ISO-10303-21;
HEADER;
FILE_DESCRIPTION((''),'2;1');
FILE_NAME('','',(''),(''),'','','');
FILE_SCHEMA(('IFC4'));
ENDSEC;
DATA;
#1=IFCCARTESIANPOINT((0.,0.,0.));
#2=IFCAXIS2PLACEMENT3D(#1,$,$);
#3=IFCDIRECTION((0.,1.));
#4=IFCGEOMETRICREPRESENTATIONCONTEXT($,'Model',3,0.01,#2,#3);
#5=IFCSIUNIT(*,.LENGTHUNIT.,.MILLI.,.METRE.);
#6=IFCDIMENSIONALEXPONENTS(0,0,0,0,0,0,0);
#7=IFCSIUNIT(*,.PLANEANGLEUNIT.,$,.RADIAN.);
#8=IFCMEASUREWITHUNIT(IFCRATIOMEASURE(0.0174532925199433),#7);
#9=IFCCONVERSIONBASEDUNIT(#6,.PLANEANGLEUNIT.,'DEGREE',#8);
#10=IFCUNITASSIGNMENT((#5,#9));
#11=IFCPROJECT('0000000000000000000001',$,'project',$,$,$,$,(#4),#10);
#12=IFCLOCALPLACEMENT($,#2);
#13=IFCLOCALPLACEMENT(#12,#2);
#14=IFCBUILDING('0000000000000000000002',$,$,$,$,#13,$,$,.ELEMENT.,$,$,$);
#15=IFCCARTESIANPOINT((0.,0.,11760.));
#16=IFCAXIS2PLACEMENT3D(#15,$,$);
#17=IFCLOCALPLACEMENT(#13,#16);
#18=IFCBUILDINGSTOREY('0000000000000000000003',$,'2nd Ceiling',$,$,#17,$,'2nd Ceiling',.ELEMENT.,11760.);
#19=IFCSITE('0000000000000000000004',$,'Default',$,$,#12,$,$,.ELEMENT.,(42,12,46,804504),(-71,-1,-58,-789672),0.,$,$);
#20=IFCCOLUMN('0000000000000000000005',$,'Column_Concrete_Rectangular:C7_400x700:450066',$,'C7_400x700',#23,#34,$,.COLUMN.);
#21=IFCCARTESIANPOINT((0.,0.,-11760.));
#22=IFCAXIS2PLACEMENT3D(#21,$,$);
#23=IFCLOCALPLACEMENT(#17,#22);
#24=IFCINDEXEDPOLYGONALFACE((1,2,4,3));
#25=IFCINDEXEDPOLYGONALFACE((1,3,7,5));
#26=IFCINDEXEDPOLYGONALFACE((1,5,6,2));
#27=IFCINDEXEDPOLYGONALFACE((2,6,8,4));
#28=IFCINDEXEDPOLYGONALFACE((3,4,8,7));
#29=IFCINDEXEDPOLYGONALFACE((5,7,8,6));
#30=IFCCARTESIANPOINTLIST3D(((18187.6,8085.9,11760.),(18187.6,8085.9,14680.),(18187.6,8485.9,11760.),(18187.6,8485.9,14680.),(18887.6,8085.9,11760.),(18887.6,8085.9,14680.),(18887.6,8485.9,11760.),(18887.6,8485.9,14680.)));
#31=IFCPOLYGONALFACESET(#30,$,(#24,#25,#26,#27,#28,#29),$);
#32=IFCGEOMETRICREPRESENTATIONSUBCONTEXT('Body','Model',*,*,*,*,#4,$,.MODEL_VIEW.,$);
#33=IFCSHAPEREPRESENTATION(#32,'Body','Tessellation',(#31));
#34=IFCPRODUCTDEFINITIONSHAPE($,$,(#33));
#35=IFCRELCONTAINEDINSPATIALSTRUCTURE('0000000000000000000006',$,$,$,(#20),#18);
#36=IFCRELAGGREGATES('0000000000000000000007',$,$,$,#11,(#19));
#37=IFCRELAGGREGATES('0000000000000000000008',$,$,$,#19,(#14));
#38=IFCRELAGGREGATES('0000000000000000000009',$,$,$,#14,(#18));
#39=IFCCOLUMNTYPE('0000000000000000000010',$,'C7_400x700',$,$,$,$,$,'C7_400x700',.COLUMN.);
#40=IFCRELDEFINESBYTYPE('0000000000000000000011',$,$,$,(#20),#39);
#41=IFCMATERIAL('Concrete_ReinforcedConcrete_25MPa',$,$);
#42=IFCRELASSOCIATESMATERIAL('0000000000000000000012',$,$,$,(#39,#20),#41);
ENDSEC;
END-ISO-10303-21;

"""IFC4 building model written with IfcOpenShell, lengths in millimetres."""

from ifc_helpers import new_model, entity, si_unit, converted_unit, direction, frame, origin, origin_2d_with_axis, place, context, subcontext, project, spatial, rectangle, extrude, source, transform, mapped, material, type_object, type_shapes, element, save


model = new_model("IFC4")

# Units and contexts
model_context = context("Model", 3, precision=0.01, world=origin(), true_north=direction((0.0, 1.0)))
body_context = subcontext(model_context, "Body", "Model", "MODEL_VIEW")
ifc_project = project(units=[si_unit("LENGTHUNIT", "METRE", prefix="MILLI"), converted_unit("PLANEANGLEUNIT", "DEGREE", entity("IfcRatioMeasure", 0.0174532925199433), si_unit("PLANEANGLEUNIT", "RADIAN"), dimensions=[0, 0, 0, 0, 0, 0, 0])], contexts=[model_context])

# Site, building, storey
site_placement = place(None, origin())
site = spatial("IfcSite", under=ifc_project, at=site_placement, Name="Default", CompositionType="ELEMENT", RefLatitude=(42, 12, 46, 804504), RefLongitude=(-71, -1, -58, -789672), RefElevation=0.0)
building_placement = place(site_placement, origin())
building = spatial("IfcBuilding", under=site, at=building_placement, CompositionType="ELEMENT")
storey_placement = place(building_placement, frame((0.0, 0.0, 11760.0)))
storey = spatial("IfcBuildingStorey", under=building, at=storey_placement, Name="2nd Ceiling", LongName="2nd Ceiling", CompositionType="ELEMENT", Elevation=11760.0)

# Column
ifc_material = material(Name="Concrete_ReinforcedConcrete_25MPa")
column_type_1 = type_object("IfcColumnType", Name="C7_400x700", ElementType="C7_400x700", PredefinedType="COLUMN", material=ifc_material)
shared_shape_1 = source(origin(), body_context, "Body", "SweptSolid", [
    extrude(rectangle(XDim=400.0, YDim=700.0, at=origin_2d_with_axis()), frame((18537.6, 8285.9, 11760.0), z_axis=(0.0, 0.0, 1.0), x_axis=(0.0, -1.0, 0.0)), (0.0, 0.0, 1.0), 2920.0),
])
type_shapes(column_type_1, [shared_shape_1])
column_1_placement = place(storey_placement, frame((0.0, 0.0, -11760.0)))
element("IfcColumn", 1, at=column_1_placement, inside=storey, type_object=column_type_1, material=ifc_material, Name="Column_Concrete_Rectangular:C7_400x700:450066", ObjectType="C7_400x700", PredefinedType="COLUMN", context=body_context, shape_type="MappedRepresentation", body=[
    mapped(shared_shape_1, transform((0.0, 0.0, 0.0), scale=1.0)),
])

save(model, "model.ifc")
